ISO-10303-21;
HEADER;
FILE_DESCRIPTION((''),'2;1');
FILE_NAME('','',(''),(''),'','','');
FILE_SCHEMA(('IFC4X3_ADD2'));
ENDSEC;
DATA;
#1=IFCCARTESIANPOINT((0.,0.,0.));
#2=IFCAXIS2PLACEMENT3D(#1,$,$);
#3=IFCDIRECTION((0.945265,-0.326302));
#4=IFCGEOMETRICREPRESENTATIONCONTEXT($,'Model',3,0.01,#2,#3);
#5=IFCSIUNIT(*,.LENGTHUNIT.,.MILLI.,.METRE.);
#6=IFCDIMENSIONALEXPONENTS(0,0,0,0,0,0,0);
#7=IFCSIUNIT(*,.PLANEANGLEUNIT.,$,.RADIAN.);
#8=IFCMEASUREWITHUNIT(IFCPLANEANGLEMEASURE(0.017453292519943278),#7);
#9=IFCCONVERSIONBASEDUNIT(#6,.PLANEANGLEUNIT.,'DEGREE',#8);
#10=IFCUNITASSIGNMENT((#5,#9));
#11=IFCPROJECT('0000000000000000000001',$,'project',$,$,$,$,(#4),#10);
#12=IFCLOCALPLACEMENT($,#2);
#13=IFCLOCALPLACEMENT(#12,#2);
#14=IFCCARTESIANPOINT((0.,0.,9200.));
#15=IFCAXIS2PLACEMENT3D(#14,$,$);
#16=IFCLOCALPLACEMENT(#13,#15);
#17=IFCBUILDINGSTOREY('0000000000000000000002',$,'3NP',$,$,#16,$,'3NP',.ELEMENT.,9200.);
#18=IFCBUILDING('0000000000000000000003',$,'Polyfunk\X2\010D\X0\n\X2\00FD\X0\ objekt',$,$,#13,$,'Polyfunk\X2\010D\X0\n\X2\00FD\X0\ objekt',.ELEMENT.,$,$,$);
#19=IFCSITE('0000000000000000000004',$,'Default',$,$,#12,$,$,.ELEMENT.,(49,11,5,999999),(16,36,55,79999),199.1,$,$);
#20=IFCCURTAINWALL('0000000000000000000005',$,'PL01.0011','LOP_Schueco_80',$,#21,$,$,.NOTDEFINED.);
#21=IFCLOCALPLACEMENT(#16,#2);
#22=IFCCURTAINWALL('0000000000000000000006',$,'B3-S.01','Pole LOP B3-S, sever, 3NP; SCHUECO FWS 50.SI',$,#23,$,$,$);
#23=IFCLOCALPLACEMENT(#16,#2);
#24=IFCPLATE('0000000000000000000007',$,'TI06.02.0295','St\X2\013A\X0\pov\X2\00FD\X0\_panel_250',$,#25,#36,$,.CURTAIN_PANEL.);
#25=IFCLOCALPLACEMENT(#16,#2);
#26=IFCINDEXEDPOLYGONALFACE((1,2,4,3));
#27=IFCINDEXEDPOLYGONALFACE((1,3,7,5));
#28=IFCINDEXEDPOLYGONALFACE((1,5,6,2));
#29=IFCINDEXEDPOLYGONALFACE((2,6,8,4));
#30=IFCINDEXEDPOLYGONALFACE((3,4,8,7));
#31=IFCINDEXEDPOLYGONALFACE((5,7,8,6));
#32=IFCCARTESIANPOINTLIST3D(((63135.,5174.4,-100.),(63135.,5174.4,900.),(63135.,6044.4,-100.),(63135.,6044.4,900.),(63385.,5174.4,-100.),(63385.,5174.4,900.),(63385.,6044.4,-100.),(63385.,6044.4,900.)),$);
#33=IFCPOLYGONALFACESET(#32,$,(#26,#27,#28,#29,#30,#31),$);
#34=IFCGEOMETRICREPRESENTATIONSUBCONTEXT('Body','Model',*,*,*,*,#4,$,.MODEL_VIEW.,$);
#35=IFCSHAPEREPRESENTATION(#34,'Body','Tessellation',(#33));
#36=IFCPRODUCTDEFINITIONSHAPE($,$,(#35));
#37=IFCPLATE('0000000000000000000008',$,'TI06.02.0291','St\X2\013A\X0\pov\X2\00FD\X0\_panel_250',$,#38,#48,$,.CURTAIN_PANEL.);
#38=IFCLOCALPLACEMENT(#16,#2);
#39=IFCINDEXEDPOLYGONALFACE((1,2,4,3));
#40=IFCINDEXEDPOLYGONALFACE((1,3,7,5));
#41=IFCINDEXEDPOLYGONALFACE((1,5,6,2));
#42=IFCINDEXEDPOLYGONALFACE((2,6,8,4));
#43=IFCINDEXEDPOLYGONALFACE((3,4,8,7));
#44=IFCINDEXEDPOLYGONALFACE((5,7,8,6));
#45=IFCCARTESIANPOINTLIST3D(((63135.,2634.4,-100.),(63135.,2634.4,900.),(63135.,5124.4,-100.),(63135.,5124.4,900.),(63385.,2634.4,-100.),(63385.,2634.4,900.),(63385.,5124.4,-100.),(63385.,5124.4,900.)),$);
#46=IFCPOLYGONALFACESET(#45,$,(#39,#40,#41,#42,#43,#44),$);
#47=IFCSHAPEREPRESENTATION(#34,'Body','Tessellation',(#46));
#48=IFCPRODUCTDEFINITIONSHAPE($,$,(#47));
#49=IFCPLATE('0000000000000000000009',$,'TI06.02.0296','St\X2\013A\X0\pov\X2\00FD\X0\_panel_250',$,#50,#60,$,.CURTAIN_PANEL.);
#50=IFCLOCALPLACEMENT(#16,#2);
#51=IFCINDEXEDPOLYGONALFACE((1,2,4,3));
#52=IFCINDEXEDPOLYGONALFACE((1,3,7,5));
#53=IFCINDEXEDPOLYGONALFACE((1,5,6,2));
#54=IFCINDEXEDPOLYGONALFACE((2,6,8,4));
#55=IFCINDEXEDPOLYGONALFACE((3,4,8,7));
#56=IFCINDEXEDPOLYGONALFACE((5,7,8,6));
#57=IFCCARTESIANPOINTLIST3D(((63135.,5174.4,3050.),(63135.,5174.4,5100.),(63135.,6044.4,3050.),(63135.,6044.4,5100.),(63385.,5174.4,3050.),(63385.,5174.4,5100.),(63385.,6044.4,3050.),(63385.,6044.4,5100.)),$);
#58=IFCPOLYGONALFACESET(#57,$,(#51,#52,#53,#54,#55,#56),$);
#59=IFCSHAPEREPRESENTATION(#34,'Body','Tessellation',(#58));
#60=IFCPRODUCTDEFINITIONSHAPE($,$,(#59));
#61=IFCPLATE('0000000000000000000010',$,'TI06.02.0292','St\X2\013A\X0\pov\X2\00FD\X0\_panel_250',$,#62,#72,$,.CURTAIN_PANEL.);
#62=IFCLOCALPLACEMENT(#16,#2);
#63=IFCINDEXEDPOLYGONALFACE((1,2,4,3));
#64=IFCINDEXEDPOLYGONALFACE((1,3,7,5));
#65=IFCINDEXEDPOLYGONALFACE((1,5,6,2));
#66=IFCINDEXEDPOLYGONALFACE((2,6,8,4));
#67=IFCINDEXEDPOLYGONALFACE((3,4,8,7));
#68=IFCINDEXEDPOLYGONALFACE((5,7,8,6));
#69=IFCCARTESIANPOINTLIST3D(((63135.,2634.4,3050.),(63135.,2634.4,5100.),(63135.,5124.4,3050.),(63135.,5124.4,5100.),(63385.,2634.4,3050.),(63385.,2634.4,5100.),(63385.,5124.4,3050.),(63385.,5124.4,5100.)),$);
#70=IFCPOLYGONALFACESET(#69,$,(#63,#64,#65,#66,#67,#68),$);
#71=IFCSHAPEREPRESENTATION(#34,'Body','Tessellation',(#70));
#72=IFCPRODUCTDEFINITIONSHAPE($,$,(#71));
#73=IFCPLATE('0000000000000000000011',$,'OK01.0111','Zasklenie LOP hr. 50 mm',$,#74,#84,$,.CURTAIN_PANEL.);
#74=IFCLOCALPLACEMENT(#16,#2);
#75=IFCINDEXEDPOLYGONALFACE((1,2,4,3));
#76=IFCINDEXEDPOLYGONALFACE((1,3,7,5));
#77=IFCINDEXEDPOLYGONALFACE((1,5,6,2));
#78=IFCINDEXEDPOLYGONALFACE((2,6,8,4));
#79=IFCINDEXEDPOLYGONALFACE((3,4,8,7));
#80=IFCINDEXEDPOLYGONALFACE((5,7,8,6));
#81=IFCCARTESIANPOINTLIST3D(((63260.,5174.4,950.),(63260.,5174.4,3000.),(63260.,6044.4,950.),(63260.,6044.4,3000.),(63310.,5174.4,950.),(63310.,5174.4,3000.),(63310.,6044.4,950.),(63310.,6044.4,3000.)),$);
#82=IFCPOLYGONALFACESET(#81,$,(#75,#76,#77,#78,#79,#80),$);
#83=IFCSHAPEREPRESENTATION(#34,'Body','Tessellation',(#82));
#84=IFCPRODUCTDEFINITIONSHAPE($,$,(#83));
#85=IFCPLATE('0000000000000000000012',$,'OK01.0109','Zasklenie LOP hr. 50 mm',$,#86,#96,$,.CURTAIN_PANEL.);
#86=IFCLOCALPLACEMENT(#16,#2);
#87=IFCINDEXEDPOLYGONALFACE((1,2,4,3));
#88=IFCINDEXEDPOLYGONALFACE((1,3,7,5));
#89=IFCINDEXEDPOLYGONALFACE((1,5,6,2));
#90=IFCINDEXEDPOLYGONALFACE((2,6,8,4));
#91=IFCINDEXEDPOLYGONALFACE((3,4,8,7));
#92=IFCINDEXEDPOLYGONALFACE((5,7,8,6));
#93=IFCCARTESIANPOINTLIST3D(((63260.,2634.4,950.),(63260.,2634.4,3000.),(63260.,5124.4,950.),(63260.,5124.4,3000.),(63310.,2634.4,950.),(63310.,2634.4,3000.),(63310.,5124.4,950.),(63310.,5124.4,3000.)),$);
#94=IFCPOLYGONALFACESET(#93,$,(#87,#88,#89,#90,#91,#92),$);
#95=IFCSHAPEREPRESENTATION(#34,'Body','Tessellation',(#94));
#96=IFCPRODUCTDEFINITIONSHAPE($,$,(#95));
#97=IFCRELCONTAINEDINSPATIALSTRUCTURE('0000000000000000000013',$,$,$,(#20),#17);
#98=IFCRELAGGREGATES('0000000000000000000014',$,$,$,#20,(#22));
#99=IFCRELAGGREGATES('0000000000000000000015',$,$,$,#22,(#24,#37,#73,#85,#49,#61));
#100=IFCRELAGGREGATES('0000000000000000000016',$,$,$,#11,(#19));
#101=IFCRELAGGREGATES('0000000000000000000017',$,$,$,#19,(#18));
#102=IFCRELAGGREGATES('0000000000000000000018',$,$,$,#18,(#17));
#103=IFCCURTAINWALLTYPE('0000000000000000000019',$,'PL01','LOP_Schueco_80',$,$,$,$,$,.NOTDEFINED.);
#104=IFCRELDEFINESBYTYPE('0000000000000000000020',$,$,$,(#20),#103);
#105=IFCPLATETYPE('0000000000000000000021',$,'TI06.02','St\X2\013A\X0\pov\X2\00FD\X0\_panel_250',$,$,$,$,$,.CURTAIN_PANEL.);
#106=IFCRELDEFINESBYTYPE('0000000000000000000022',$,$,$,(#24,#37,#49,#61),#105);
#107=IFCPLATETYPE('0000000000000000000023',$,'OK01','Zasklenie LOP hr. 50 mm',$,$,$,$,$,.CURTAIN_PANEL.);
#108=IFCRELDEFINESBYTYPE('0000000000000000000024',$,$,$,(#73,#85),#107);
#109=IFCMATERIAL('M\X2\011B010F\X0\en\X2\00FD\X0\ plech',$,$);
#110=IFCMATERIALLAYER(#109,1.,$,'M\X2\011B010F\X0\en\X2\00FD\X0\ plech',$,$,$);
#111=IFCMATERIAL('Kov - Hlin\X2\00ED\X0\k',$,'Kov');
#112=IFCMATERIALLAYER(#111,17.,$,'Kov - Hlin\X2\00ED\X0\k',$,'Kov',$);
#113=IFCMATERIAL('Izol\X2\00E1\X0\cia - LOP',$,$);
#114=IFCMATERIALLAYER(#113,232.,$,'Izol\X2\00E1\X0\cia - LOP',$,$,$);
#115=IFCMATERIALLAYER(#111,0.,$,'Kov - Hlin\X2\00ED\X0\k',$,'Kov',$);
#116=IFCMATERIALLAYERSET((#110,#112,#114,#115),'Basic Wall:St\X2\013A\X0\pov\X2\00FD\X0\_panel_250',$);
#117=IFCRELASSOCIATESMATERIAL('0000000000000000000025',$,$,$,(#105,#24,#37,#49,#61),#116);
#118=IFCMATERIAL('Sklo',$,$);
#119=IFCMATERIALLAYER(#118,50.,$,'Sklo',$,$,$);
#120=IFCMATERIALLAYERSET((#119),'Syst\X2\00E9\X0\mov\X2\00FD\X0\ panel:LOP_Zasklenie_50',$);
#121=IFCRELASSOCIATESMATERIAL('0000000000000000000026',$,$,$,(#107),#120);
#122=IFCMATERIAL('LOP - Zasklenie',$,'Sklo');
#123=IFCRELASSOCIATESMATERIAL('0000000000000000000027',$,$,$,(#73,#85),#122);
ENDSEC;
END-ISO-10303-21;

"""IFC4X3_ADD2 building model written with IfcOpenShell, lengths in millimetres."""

from ifc_helpers import new_model, entity, si_unit, converted_unit, direction, frame, frame_2d, origin, origin_2d_with_axis, place, context, subcontext, project, spatial, rectangle, extrude, source, transform, mapped, material, layer, layer_set, layer_usage, type_object, type_shapes, element, aggregate, save


model = new_model("IFC4X3_ADD2")

# Units and contexts
model_context = context("Model", 3, precision=0.01, world=origin(), true_north=direction((0.945265, -0.326302)))
body_context = subcontext(model_context, "Body", "Model", "MODEL_VIEW")
ifc_project = project(units=[si_unit("LENGTHUNIT", "METRE", prefix="MILLI"), converted_unit("PLANEANGLEUNIT", "DEGREE", entity("IfcPlaneAngleMeasure", 0.017453292519943278), si_unit("PLANEANGLEUNIT", "RADIAN"), dimensions=[0, 0, 0, 0, 0, 0, 0])], contexts=[model_context])

# Site, building, storey
site_placement = place(None, origin())
site = spatial("IfcSite", under=ifc_project, at=site_placement, Name="Default", CompositionType="ELEMENT", RefLatitude=(49, 11, 5, 999999), RefLongitude=(16, 36, 55, 79999), RefElevation=199.1)
building_placement = place(site_placement, origin())
building = spatial("IfcBuilding", under=site, at=building_placement, Name="Polyfunkčný objekt", LongName="Polyfunkčný objekt", CompositionType="ELEMENT")
storey_placement = place(building_placement, frame((0.0, 0.0, 9200.0)))
storey = spatial("IfcBuildingStorey", under=building, at=storey_placement, Name="3NP", LongName="3NP", CompositionType="ELEMENT", Elevation=9200.0)

# Curtain walls, plates
curtain_wall_type = type_object("IfcCurtainWallType", Name="PL01", Description="LOP_Schueco_80", PredefinedType="NOTDEFINED")
curtain_wall_1_placement = place(storey_placement, frame((0.0, 0.0, -9200.0)))
curtain_wall_1 = element("IfcCurtainWall", 1, at=curtain_wall_1_placement, inside=storey, type_object=curtain_wall_type, Name="PL01.0011", Description="LOP_Schueco_80", PredefinedType="NOTDEFINED")
curtain_wall_2 = element("IfcCurtainWall", 2, Name="B3-S.01", Description="Pole LOP B3-S, sever, 3NP; SCHUECO FWS 50.SI")
aggregate(curtain_wall_1, [curtain_wall_2])
ifc_material_1 = material(Name="Měďený plech")
ifc_layer_1 = layer(ifc_material_1, 1.0, Name="Měďený plech")
ifc_material_2 = material(Name="Kov - Hliník", Category="Kov")
ifc_layer_2 = layer(ifc_material_2, 17.0, Name="Kov - Hliník", Category="Kov")
ifc_material_3 = material(Name="Izolácia - LOP")
ifc_layer_3 = layer(ifc_material_3, 232.0, Name="Izolácia - LOP")
ifc_layer_4 = layer(ifc_material_2, 0.0, Name="Kov - Hliník", Category="Kov")
ifc_layer_set_1 = layer_set([ifc_layer_1, ifc_layer_2, ifc_layer_3, ifc_layer_4], Name="Basic Wall:Stĺpový_panel_250")
ifc_layer_usage_1 = layer_usage(ifc_layer_set_1, "AXIS2", "NEGATIVE", 125.0)
plate_type_1 = type_object("IfcPlateType", Name="TI06.02", Description="Stĺpový_panel_250", PredefinedType="CURTAIN_PANEL", material=ifc_layer_set_1)
plate_1_placement = place(storey_placement, frame((63260.0, 6044.4, -100.0), z_axis=(0.0, 0.0, 1.0), x_axis=(0.0, -1.0, 0.0)))
plate_1 = element("IfcPlate", 3, at=plate_1_placement, type_object=plate_type_1, material=ifc_layer_usage_1, Name="TI06.02.0295", Description="Stĺpový_panel_250", PredefinedType="CURTAIN_PANEL", context=body_context, shape_type="SweptSolid", body=[
    extrude(rectangle(XDim=250.0, YDim=870.0, at=frame_2d((0.0, 0.0), x_axis=(1.0, 0.0))), frame((435.0, 0.0, 0.0), z_axis=(0.0, 0.0, 1.0), x_axis=(0.0, 1.0, 0.0)), (0.0, 0.0, 1.0), 1000.0),
])
ifc_layer_usage_2 = layer_usage(ifc_layer_set_1, "AXIS2", "NEGATIVE", 125.0)
plate_2_placement = place(storey_placement, frame((63260.0, 5124.4, -100.0), z_axis=(0.0, 0.0, 1.0), x_axis=(0.0, -1.0, 0.0)))
plate_2 = element("IfcPlate", 4, at=plate_2_placement, type_object=plate_type_1, material=ifc_layer_usage_2, Name="TI06.02.0291", Description="Stĺpový_panel_250", PredefinedType="CURTAIN_PANEL", context=body_context, shape_type="SweptSolid", body=[
    extrude(rectangle(XDim=250.0, YDim=2490.0, at=origin_2d_with_axis()), frame((1245.0, 0.0, 0.0), z_axis=(0.0, 0.0, 1.0), x_axis=(0.0, 1.0, 0.0)), (0.0, 0.0, 1.0), 1000.0),
])
ifc_layer_usage_3 = layer_usage(ifc_layer_set_1, "AXIS2", "NEGATIVE", 125.0)
plate_3_placement = place(storey_placement, frame((63260.0, 6044.4, 3050.0), z_axis=(0.0, 0.0, 1.0), x_axis=(0.0, -1.0, 0.0)))
plate_3 = element("IfcPlate", 5, at=plate_3_placement, type_object=plate_type_1, material=ifc_layer_usage_3, Name="TI06.02.0296", Description="Stĺpový_panel_250", PredefinedType="CURTAIN_PANEL", context=body_context, shape_type="SweptSolid", body=[
    extrude(rectangle(XDim=250.0, YDim=870.0, at=frame_2d((0.0, 0.0), x_axis=(1.0, 0.0))), frame((435.0, 0.0, 0.0), z_axis=(0.0, 0.0, 1.0), x_axis=(0.0, 1.0, 0.0)), (0.0, 0.0, 1.0), 2050.0),
])
ifc_layer_usage_4 = layer_usage(ifc_layer_set_1, "AXIS2", "NEGATIVE", 125.0)
plate_4_placement = place(storey_placement, frame((63260.0, 5124.4, 3050.0), z_axis=(0.0, 0.0, 1.0), x_axis=(0.0, -1.0, 0.0)))
plate_4 = element("IfcPlate", 6, at=plate_4_placement, type_object=plate_type_1, material=ifc_layer_usage_4, Name="TI06.02.0292", Description="Stĺpový_panel_250", PredefinedType="CURTAIN_PANEL", context=body_context, shape_type="SweptSolid", body=[
    extrude(rectangle(XDim=250.0, YDim=2490.0, at=frame_2d((0.0, 0.0), x_axis=(1.0, 0.0))), frame((1245.0, 0.0, 0.0), z_axis=(0.0, 0.0, 1.0), x_axis=(0.0, 1.0, 0.0)), (0.0, 0.0, 1.0), 2050.0),
])
ifc_material_4 = material(Name="LOP - Zasklenie", Category="Sklo")
ifc_material_5 = material(Name="Sklo")
ifc_layer_5 = layer(ifc_material_5, 50.0, Name="Sklo")
ifc_layer_set_2 = layer_set([ifc_layer_5], Name="Systémový panel:LOP_Zasklenie_50")
plate_type_2 = type_object("IfcPlateType", Name="OK01", Description="Zasklenie LOP hr. 50 mm", PredefinedType="CURTAIN_PANEL", material=ifc_layer_set_2)
shared_shape_1 = source(origin(), body_context, "Body", "SweptSolid", [
    extrude(rectangle(XDim=50.0, YDim=870.0, at=origin_2d_with_axis()), frame((0.0, 25.0, 0.0), z_axis=(0.0, 0.0, 1.0), x_axis=(0.0, 1.0, 0.0)), (0.0, 0.0, 1.0), 2050.0),
])
plate_5_placement = place(curtain_wall_1_placement, frame((63260.0, 5609.4, 10150.0), z_axis=(0.0, 0.0, 1.0), x_axis=(0.0, -1.0, 0.0)))
plate_5 = element("IfcPlate", 7, at=plate_5_placement, type_object=plate_type_2, material=ifc_material_4, Name="OK01.0111", Description="Zasklenie LOP hr. 50 mm", PredefinedType="CURTAIN_PANEL", context=body_context, shape_type="MappedRepresentation", body=[
    mapped(shared_shape_1, transform((0.0, 0.0, 0.0), scale=1.0)),
])
shared_shape_2 = source(origin(), body_context, "Body", "SweptSolid", [
    extrude(rectangle(XDim=50.0, YDim=2490.0, at=origin_2d_with_axis()), frame((0.0, 25.0, 0.0), z_axis=(0.0, 0.0, 1.0), x_axis=(0.0, 1.0, 0.0)), (0.0, 0.0, 1.0), 2050.0),
])
type_shapes(plate_type_2, [shared_shape_1, shared_shape_2])
plate_6_placement = place(curtain_wall_1_placement, frame((63260.0, 3879.4, 10150.0), z_axis=(0.0, 0.0, 1.0), x_axis=(0.0, -1.0, 0.0)))
plate_6 = element("IfcPlate", 8, at=plate_6_placement, type_object=plate_type_2, material=ifc_material_4, Name="OK01.0109", Description="Zasklenie LOP hr. 50 mm", PredefinedType="CURTAIN_PANEL", context=body_context, shape_type="MappedRepresentation", body=[
    mapped(shared_shape_2, transform((0.0, 0.0, 0.0), scale=1.0)),
])
aggregate(curtain_wall_2, [plate_1, plate_2, plate_5, plate_6, plate_3, plate_4])

save(model, "model.ifc")
